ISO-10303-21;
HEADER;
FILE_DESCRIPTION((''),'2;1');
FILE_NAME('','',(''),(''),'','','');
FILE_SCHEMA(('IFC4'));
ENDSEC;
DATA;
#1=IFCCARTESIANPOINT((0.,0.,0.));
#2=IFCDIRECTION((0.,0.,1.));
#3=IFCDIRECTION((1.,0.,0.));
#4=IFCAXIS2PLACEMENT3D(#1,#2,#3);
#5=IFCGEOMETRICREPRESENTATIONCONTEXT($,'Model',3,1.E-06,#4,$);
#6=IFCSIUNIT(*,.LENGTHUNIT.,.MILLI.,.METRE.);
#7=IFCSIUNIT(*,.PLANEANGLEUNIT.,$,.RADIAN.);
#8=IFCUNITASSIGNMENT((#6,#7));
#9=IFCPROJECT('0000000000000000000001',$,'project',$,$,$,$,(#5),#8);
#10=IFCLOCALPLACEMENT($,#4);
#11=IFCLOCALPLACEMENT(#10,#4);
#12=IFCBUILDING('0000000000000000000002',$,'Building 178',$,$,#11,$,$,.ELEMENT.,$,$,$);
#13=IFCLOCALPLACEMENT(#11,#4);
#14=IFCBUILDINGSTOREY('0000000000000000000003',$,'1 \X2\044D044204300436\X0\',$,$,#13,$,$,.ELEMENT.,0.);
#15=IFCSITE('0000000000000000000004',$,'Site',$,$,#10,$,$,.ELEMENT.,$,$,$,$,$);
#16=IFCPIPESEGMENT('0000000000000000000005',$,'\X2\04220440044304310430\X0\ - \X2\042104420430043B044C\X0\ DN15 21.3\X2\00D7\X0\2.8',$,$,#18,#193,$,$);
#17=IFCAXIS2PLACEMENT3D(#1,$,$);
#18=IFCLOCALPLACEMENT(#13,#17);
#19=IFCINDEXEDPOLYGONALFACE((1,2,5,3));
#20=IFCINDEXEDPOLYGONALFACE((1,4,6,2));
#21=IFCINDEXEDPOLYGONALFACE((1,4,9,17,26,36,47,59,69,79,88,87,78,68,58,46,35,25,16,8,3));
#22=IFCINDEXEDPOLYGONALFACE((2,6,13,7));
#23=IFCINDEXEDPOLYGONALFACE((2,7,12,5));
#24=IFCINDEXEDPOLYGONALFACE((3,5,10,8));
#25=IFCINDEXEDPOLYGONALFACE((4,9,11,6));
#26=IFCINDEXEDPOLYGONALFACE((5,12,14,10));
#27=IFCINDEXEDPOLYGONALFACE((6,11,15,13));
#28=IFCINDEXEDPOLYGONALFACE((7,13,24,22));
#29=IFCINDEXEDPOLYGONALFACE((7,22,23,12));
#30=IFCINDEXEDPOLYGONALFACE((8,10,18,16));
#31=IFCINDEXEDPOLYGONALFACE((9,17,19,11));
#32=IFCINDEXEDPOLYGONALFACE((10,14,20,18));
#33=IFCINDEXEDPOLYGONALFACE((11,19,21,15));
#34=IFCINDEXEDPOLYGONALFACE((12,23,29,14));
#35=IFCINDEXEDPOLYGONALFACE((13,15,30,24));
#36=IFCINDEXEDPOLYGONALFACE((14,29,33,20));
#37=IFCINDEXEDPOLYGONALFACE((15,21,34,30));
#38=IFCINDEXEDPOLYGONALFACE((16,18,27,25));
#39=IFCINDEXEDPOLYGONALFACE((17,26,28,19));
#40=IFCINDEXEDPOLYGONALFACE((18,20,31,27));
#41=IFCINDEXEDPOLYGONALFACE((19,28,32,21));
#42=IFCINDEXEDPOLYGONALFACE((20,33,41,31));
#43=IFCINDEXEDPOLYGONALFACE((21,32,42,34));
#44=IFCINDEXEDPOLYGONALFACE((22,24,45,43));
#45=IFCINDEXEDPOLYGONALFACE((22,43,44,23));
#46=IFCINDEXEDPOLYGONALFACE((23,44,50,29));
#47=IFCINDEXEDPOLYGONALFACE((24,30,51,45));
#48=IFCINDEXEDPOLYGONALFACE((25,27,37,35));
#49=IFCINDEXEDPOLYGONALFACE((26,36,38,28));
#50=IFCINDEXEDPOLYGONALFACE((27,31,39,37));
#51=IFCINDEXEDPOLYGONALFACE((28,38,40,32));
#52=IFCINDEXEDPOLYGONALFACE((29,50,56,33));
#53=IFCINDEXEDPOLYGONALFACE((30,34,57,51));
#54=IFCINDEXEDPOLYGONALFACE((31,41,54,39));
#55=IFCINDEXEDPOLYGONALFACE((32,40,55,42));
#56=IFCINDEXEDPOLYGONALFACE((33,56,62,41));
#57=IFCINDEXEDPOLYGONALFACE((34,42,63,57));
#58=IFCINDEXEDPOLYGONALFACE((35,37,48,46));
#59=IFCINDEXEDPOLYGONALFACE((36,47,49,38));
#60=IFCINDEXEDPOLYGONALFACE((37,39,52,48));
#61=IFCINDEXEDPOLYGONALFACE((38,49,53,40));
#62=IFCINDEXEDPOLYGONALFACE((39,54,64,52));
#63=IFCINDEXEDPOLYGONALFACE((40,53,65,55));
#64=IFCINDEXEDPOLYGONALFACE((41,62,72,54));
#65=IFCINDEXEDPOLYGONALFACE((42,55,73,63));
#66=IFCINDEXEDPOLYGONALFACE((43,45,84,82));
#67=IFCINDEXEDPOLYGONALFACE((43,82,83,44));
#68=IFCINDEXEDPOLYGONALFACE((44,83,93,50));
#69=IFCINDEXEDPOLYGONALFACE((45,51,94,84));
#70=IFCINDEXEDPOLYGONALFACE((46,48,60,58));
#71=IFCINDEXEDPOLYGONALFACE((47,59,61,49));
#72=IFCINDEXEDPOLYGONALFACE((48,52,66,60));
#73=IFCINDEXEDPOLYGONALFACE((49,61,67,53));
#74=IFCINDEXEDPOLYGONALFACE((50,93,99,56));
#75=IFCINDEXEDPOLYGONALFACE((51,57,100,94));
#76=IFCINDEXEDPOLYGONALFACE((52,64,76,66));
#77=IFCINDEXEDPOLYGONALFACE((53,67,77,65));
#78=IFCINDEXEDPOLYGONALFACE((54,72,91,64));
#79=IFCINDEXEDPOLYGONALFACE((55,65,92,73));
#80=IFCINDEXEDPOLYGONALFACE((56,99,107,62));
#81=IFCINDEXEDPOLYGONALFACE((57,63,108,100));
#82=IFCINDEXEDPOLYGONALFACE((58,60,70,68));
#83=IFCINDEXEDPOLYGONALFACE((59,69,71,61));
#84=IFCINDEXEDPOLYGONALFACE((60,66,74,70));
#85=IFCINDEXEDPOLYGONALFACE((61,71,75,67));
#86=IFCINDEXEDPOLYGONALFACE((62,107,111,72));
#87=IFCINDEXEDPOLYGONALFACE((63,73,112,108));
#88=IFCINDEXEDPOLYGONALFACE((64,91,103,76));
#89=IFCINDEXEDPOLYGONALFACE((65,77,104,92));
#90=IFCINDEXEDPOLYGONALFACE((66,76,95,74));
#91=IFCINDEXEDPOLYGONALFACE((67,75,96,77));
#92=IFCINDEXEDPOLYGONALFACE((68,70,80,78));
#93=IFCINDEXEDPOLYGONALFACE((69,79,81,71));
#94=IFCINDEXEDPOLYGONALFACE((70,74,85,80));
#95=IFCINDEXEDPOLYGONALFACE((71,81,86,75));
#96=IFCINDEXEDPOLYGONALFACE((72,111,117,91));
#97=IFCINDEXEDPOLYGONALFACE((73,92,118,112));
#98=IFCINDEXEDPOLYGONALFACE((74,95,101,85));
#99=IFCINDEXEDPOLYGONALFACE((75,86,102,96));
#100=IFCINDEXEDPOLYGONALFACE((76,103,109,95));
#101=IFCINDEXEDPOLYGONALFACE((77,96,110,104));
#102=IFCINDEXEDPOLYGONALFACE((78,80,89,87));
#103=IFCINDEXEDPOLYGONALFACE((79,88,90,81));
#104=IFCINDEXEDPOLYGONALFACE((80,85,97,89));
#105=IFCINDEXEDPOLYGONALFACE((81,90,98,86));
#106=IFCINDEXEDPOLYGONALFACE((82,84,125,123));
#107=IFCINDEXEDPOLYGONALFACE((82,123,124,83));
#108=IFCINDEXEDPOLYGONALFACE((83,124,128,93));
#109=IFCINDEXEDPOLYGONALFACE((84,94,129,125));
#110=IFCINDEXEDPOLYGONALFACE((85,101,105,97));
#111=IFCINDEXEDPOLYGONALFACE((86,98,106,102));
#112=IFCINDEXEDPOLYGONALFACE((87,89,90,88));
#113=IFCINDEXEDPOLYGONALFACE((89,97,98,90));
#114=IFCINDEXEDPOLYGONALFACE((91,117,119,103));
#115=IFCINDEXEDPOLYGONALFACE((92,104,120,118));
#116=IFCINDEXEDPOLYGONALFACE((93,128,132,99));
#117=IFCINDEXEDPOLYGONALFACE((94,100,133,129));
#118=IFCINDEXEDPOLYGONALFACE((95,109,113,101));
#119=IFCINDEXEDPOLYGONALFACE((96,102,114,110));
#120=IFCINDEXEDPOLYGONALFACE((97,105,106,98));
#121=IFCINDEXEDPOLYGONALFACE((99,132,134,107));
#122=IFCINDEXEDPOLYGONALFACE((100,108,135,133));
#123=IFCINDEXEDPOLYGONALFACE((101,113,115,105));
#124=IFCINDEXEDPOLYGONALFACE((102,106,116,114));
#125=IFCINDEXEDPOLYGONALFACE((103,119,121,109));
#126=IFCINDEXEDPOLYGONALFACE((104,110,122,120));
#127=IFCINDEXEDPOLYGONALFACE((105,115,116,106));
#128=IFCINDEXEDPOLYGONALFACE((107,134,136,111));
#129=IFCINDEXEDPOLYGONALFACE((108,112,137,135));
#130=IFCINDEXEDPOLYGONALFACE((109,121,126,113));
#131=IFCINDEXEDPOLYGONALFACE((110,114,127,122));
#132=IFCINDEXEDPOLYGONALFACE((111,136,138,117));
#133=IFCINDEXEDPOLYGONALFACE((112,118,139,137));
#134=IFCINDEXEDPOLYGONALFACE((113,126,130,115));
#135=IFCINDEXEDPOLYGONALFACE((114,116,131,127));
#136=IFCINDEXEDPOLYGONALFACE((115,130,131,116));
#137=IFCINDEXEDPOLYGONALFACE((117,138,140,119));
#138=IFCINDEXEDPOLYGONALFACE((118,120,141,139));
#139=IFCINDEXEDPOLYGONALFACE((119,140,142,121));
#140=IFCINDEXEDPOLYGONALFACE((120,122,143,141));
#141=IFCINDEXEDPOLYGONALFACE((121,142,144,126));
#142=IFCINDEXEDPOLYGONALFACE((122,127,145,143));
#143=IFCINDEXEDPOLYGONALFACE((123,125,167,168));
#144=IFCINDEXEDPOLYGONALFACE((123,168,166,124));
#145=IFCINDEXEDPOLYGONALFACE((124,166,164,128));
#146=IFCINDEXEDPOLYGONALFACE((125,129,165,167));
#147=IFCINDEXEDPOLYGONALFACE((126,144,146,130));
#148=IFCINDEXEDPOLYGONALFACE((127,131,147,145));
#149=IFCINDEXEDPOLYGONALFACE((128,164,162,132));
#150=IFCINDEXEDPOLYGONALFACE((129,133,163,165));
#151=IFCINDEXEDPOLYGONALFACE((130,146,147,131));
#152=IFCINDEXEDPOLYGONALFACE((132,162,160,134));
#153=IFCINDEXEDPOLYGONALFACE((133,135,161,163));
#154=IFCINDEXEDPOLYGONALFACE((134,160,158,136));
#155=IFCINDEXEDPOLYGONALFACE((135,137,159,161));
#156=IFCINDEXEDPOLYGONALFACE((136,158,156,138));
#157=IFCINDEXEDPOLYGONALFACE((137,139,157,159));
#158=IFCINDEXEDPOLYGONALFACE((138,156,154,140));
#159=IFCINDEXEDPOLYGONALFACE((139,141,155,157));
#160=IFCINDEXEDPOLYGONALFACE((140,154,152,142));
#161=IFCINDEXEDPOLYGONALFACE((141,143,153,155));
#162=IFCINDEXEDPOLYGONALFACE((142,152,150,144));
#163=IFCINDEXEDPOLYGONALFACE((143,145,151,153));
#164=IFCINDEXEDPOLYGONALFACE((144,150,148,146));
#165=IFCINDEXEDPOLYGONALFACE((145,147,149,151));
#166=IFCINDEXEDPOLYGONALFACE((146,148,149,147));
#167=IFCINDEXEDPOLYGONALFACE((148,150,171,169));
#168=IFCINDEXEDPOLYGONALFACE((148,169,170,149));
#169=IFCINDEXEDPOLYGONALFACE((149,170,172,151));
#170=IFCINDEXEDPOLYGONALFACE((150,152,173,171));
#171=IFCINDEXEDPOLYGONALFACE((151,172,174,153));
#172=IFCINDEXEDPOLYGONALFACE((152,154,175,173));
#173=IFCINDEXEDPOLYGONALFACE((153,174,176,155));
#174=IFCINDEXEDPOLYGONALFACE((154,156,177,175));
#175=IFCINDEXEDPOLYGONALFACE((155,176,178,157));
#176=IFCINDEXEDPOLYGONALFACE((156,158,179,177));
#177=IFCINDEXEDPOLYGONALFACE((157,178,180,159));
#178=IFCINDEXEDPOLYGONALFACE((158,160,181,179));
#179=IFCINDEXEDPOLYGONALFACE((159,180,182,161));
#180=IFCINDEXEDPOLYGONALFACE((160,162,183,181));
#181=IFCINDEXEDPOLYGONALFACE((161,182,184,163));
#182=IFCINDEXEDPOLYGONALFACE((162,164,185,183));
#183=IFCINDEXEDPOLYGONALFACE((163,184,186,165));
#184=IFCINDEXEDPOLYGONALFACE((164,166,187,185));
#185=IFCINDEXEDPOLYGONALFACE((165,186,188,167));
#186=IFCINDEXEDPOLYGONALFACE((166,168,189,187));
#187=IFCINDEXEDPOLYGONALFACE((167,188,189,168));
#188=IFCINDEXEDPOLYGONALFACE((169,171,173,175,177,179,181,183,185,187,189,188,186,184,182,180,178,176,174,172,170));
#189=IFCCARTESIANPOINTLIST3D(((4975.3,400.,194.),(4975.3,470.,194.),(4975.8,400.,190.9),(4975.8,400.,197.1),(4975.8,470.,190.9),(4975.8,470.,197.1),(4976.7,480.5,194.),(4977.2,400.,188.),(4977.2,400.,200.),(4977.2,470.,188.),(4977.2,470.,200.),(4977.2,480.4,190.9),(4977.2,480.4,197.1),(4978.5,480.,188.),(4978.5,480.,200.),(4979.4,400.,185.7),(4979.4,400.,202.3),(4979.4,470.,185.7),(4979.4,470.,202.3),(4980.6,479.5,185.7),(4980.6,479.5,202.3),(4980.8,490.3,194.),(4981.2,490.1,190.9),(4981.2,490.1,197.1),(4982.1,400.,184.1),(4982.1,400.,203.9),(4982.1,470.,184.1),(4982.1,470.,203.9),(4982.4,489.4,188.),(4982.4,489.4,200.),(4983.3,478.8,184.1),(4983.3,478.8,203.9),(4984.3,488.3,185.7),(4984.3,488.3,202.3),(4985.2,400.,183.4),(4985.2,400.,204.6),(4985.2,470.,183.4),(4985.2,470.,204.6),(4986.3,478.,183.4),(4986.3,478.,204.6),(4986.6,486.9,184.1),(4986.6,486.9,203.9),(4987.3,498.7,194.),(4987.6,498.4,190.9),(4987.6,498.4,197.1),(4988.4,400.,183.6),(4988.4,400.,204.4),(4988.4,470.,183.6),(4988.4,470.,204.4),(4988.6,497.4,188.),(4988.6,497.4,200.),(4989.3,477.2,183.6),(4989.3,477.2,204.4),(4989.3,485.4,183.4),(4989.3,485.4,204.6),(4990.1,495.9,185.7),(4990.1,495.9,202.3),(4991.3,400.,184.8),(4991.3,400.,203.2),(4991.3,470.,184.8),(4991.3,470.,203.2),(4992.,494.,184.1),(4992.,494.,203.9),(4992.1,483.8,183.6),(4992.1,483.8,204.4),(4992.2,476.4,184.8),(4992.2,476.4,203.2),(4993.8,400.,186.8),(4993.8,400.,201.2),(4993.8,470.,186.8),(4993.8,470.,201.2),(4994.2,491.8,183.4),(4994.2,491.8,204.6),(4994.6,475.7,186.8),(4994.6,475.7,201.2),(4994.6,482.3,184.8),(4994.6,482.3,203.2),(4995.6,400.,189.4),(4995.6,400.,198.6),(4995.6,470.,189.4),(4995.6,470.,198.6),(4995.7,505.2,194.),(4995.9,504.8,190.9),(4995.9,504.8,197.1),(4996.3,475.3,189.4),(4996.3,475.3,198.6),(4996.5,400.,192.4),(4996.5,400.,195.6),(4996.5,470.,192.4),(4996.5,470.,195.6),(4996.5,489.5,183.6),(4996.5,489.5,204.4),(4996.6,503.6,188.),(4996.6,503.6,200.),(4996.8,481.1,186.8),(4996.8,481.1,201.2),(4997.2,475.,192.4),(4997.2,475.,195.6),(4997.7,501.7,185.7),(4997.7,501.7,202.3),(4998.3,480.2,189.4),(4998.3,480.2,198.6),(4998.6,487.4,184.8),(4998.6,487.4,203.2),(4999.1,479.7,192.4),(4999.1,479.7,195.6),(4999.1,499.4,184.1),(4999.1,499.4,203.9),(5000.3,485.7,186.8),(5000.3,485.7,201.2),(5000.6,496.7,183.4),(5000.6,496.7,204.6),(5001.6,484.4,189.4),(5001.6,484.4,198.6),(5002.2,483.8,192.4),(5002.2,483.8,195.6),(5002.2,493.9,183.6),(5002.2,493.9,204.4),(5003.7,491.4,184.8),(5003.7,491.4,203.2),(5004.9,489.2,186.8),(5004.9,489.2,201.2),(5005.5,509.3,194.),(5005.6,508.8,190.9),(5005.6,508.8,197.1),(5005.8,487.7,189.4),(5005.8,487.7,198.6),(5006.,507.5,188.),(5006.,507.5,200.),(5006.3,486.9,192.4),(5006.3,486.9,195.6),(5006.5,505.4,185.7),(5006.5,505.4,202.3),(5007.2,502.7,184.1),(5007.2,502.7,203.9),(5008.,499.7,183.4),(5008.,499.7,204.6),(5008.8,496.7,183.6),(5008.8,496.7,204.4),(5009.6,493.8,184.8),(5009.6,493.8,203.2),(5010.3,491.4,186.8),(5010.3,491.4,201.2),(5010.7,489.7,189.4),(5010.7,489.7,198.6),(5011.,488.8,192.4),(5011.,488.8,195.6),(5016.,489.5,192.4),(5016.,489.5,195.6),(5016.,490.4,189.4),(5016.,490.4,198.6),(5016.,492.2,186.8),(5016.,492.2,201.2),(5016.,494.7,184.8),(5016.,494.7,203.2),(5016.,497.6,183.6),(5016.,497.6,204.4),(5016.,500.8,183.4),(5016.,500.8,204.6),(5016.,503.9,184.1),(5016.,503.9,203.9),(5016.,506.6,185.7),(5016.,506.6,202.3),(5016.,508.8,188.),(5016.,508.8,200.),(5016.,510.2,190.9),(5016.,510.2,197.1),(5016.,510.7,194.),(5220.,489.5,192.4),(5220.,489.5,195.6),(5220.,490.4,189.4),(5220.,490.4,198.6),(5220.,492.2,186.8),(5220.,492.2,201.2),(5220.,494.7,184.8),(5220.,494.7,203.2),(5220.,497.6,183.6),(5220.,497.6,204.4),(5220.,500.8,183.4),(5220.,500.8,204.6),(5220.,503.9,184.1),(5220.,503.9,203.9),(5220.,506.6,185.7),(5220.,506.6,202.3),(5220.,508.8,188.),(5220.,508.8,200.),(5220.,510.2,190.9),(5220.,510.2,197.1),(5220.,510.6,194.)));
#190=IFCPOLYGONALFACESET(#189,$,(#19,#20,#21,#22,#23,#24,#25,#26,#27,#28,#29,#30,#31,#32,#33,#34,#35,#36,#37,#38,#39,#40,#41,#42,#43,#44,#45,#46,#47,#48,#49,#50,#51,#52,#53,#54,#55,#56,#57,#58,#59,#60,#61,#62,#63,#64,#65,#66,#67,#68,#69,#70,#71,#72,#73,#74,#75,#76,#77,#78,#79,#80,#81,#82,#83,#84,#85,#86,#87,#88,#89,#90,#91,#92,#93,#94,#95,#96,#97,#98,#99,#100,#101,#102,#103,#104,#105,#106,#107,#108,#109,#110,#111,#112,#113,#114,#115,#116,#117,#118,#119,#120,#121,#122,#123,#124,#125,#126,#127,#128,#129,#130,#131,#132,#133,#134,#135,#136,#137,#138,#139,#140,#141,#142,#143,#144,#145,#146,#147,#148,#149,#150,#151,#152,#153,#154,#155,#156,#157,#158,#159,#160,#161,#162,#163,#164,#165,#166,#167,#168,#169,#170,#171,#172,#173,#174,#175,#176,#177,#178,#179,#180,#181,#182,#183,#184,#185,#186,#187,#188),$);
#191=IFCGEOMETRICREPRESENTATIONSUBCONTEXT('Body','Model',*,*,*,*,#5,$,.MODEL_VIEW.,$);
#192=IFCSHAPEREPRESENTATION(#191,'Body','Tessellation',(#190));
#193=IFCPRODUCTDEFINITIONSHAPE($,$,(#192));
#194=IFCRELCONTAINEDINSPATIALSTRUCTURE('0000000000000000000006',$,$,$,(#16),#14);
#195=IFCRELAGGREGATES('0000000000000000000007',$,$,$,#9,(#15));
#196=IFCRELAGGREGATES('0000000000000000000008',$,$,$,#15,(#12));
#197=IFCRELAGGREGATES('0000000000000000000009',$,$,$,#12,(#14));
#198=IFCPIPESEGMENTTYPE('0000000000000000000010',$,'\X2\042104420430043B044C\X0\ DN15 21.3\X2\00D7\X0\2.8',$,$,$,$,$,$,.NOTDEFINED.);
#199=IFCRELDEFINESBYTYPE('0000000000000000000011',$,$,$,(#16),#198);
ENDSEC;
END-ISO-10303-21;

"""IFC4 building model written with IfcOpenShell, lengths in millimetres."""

from ifc_helpers import new_model, entity, si_unit, frame, origin_with_axes, place, context, subcontext, project, spatial, source, transform, mapped, type_object, element, save


model = new_model("IFC4")

# Units and contexts
model_context = context("Model", 3, precision=1e-06, world=origin_with_axes())
body_context = subcontext(model_context, "Body", "Model", "MODEL_VIEW")
ifc_project = project(units=[si_unit("LENGTHUNIT", "METRE", prefix="MILLI"), si_unit("PLANEANGLEUNIT", "RADIAN")], contexts=[model_context])

# Site, building, storey
site_placement = place(None, origin_with_axes())
site = spatial("IfcSite", under=ifc_project, at=site_placement, Name="Site", CompositionType="ELEMENT")
building_placement = place(site_placement, origin_with_axes())
building = spatial("IfcBuilding", under=site, at=building_placement, Name="Building 178", CompositionType="ELEMENT")
storey_placement = place(building_placement, origin_with_axes())
storey = spatial("IfcBuildingStorey", under=building, at=storey_placement, Name="1 этаж", CompositionType="ELEMENT", Elevation=0.0)

# Pipe segment
pipe_segment_type = type_object("IfcPipeSegmentType", Name="Сталь DN15 21.3×2.8", PredefinedType="NOTDEFINED")
shared_shape_1 = source(origin_with_axes(), body_context, "Body", "AdvancedSweptSolid", [
    entity("IfcSweptDiskSolid", entity("IfcIndexedPolyCurve", entity("IfcCartesianPointList3D", [[0.0, 0.0, 0.0], [0.0, 0.0, -70.0], [8.8, 0.0, -91.2], [30.0, 0.0, -100.0], [234.0, 0.0, -100.0]]), [entity("IfcLineIndex", [1, 2]), entity("IfcArcIndex", [2, 3, 4]), entity("IfcLineIndex", [4, 5])]), 10.7),
])
for number, where, z_axis, x_axis, name in (
    (1, (4986.0, 400.0, 194.0), (0.0, -1.0, 0.0), (1.0, 0.0, 0.0), "Труба - Сталь DN15 21.3×2.8"),
):
    element("IfcPipeSegment", number, at=place(storey_placement, frame(where, z_axis=z_axis, x_axis=x_axis)), inside=storey, type_object=pipe_segment_type, Name=name, context=body_context, shape_type="MappedRepresentation", body=[
        mapped(shared_shape_1, transform((0.0, 0.0, 0.0), x_axis=(1.0, 0.0, 0.0), y_axis=(0.0, 1.0, 0.0), z_axis=(0.0, 0.0, 1.0), scale=1.0)),
    ])

save(model, "model.ifc")
